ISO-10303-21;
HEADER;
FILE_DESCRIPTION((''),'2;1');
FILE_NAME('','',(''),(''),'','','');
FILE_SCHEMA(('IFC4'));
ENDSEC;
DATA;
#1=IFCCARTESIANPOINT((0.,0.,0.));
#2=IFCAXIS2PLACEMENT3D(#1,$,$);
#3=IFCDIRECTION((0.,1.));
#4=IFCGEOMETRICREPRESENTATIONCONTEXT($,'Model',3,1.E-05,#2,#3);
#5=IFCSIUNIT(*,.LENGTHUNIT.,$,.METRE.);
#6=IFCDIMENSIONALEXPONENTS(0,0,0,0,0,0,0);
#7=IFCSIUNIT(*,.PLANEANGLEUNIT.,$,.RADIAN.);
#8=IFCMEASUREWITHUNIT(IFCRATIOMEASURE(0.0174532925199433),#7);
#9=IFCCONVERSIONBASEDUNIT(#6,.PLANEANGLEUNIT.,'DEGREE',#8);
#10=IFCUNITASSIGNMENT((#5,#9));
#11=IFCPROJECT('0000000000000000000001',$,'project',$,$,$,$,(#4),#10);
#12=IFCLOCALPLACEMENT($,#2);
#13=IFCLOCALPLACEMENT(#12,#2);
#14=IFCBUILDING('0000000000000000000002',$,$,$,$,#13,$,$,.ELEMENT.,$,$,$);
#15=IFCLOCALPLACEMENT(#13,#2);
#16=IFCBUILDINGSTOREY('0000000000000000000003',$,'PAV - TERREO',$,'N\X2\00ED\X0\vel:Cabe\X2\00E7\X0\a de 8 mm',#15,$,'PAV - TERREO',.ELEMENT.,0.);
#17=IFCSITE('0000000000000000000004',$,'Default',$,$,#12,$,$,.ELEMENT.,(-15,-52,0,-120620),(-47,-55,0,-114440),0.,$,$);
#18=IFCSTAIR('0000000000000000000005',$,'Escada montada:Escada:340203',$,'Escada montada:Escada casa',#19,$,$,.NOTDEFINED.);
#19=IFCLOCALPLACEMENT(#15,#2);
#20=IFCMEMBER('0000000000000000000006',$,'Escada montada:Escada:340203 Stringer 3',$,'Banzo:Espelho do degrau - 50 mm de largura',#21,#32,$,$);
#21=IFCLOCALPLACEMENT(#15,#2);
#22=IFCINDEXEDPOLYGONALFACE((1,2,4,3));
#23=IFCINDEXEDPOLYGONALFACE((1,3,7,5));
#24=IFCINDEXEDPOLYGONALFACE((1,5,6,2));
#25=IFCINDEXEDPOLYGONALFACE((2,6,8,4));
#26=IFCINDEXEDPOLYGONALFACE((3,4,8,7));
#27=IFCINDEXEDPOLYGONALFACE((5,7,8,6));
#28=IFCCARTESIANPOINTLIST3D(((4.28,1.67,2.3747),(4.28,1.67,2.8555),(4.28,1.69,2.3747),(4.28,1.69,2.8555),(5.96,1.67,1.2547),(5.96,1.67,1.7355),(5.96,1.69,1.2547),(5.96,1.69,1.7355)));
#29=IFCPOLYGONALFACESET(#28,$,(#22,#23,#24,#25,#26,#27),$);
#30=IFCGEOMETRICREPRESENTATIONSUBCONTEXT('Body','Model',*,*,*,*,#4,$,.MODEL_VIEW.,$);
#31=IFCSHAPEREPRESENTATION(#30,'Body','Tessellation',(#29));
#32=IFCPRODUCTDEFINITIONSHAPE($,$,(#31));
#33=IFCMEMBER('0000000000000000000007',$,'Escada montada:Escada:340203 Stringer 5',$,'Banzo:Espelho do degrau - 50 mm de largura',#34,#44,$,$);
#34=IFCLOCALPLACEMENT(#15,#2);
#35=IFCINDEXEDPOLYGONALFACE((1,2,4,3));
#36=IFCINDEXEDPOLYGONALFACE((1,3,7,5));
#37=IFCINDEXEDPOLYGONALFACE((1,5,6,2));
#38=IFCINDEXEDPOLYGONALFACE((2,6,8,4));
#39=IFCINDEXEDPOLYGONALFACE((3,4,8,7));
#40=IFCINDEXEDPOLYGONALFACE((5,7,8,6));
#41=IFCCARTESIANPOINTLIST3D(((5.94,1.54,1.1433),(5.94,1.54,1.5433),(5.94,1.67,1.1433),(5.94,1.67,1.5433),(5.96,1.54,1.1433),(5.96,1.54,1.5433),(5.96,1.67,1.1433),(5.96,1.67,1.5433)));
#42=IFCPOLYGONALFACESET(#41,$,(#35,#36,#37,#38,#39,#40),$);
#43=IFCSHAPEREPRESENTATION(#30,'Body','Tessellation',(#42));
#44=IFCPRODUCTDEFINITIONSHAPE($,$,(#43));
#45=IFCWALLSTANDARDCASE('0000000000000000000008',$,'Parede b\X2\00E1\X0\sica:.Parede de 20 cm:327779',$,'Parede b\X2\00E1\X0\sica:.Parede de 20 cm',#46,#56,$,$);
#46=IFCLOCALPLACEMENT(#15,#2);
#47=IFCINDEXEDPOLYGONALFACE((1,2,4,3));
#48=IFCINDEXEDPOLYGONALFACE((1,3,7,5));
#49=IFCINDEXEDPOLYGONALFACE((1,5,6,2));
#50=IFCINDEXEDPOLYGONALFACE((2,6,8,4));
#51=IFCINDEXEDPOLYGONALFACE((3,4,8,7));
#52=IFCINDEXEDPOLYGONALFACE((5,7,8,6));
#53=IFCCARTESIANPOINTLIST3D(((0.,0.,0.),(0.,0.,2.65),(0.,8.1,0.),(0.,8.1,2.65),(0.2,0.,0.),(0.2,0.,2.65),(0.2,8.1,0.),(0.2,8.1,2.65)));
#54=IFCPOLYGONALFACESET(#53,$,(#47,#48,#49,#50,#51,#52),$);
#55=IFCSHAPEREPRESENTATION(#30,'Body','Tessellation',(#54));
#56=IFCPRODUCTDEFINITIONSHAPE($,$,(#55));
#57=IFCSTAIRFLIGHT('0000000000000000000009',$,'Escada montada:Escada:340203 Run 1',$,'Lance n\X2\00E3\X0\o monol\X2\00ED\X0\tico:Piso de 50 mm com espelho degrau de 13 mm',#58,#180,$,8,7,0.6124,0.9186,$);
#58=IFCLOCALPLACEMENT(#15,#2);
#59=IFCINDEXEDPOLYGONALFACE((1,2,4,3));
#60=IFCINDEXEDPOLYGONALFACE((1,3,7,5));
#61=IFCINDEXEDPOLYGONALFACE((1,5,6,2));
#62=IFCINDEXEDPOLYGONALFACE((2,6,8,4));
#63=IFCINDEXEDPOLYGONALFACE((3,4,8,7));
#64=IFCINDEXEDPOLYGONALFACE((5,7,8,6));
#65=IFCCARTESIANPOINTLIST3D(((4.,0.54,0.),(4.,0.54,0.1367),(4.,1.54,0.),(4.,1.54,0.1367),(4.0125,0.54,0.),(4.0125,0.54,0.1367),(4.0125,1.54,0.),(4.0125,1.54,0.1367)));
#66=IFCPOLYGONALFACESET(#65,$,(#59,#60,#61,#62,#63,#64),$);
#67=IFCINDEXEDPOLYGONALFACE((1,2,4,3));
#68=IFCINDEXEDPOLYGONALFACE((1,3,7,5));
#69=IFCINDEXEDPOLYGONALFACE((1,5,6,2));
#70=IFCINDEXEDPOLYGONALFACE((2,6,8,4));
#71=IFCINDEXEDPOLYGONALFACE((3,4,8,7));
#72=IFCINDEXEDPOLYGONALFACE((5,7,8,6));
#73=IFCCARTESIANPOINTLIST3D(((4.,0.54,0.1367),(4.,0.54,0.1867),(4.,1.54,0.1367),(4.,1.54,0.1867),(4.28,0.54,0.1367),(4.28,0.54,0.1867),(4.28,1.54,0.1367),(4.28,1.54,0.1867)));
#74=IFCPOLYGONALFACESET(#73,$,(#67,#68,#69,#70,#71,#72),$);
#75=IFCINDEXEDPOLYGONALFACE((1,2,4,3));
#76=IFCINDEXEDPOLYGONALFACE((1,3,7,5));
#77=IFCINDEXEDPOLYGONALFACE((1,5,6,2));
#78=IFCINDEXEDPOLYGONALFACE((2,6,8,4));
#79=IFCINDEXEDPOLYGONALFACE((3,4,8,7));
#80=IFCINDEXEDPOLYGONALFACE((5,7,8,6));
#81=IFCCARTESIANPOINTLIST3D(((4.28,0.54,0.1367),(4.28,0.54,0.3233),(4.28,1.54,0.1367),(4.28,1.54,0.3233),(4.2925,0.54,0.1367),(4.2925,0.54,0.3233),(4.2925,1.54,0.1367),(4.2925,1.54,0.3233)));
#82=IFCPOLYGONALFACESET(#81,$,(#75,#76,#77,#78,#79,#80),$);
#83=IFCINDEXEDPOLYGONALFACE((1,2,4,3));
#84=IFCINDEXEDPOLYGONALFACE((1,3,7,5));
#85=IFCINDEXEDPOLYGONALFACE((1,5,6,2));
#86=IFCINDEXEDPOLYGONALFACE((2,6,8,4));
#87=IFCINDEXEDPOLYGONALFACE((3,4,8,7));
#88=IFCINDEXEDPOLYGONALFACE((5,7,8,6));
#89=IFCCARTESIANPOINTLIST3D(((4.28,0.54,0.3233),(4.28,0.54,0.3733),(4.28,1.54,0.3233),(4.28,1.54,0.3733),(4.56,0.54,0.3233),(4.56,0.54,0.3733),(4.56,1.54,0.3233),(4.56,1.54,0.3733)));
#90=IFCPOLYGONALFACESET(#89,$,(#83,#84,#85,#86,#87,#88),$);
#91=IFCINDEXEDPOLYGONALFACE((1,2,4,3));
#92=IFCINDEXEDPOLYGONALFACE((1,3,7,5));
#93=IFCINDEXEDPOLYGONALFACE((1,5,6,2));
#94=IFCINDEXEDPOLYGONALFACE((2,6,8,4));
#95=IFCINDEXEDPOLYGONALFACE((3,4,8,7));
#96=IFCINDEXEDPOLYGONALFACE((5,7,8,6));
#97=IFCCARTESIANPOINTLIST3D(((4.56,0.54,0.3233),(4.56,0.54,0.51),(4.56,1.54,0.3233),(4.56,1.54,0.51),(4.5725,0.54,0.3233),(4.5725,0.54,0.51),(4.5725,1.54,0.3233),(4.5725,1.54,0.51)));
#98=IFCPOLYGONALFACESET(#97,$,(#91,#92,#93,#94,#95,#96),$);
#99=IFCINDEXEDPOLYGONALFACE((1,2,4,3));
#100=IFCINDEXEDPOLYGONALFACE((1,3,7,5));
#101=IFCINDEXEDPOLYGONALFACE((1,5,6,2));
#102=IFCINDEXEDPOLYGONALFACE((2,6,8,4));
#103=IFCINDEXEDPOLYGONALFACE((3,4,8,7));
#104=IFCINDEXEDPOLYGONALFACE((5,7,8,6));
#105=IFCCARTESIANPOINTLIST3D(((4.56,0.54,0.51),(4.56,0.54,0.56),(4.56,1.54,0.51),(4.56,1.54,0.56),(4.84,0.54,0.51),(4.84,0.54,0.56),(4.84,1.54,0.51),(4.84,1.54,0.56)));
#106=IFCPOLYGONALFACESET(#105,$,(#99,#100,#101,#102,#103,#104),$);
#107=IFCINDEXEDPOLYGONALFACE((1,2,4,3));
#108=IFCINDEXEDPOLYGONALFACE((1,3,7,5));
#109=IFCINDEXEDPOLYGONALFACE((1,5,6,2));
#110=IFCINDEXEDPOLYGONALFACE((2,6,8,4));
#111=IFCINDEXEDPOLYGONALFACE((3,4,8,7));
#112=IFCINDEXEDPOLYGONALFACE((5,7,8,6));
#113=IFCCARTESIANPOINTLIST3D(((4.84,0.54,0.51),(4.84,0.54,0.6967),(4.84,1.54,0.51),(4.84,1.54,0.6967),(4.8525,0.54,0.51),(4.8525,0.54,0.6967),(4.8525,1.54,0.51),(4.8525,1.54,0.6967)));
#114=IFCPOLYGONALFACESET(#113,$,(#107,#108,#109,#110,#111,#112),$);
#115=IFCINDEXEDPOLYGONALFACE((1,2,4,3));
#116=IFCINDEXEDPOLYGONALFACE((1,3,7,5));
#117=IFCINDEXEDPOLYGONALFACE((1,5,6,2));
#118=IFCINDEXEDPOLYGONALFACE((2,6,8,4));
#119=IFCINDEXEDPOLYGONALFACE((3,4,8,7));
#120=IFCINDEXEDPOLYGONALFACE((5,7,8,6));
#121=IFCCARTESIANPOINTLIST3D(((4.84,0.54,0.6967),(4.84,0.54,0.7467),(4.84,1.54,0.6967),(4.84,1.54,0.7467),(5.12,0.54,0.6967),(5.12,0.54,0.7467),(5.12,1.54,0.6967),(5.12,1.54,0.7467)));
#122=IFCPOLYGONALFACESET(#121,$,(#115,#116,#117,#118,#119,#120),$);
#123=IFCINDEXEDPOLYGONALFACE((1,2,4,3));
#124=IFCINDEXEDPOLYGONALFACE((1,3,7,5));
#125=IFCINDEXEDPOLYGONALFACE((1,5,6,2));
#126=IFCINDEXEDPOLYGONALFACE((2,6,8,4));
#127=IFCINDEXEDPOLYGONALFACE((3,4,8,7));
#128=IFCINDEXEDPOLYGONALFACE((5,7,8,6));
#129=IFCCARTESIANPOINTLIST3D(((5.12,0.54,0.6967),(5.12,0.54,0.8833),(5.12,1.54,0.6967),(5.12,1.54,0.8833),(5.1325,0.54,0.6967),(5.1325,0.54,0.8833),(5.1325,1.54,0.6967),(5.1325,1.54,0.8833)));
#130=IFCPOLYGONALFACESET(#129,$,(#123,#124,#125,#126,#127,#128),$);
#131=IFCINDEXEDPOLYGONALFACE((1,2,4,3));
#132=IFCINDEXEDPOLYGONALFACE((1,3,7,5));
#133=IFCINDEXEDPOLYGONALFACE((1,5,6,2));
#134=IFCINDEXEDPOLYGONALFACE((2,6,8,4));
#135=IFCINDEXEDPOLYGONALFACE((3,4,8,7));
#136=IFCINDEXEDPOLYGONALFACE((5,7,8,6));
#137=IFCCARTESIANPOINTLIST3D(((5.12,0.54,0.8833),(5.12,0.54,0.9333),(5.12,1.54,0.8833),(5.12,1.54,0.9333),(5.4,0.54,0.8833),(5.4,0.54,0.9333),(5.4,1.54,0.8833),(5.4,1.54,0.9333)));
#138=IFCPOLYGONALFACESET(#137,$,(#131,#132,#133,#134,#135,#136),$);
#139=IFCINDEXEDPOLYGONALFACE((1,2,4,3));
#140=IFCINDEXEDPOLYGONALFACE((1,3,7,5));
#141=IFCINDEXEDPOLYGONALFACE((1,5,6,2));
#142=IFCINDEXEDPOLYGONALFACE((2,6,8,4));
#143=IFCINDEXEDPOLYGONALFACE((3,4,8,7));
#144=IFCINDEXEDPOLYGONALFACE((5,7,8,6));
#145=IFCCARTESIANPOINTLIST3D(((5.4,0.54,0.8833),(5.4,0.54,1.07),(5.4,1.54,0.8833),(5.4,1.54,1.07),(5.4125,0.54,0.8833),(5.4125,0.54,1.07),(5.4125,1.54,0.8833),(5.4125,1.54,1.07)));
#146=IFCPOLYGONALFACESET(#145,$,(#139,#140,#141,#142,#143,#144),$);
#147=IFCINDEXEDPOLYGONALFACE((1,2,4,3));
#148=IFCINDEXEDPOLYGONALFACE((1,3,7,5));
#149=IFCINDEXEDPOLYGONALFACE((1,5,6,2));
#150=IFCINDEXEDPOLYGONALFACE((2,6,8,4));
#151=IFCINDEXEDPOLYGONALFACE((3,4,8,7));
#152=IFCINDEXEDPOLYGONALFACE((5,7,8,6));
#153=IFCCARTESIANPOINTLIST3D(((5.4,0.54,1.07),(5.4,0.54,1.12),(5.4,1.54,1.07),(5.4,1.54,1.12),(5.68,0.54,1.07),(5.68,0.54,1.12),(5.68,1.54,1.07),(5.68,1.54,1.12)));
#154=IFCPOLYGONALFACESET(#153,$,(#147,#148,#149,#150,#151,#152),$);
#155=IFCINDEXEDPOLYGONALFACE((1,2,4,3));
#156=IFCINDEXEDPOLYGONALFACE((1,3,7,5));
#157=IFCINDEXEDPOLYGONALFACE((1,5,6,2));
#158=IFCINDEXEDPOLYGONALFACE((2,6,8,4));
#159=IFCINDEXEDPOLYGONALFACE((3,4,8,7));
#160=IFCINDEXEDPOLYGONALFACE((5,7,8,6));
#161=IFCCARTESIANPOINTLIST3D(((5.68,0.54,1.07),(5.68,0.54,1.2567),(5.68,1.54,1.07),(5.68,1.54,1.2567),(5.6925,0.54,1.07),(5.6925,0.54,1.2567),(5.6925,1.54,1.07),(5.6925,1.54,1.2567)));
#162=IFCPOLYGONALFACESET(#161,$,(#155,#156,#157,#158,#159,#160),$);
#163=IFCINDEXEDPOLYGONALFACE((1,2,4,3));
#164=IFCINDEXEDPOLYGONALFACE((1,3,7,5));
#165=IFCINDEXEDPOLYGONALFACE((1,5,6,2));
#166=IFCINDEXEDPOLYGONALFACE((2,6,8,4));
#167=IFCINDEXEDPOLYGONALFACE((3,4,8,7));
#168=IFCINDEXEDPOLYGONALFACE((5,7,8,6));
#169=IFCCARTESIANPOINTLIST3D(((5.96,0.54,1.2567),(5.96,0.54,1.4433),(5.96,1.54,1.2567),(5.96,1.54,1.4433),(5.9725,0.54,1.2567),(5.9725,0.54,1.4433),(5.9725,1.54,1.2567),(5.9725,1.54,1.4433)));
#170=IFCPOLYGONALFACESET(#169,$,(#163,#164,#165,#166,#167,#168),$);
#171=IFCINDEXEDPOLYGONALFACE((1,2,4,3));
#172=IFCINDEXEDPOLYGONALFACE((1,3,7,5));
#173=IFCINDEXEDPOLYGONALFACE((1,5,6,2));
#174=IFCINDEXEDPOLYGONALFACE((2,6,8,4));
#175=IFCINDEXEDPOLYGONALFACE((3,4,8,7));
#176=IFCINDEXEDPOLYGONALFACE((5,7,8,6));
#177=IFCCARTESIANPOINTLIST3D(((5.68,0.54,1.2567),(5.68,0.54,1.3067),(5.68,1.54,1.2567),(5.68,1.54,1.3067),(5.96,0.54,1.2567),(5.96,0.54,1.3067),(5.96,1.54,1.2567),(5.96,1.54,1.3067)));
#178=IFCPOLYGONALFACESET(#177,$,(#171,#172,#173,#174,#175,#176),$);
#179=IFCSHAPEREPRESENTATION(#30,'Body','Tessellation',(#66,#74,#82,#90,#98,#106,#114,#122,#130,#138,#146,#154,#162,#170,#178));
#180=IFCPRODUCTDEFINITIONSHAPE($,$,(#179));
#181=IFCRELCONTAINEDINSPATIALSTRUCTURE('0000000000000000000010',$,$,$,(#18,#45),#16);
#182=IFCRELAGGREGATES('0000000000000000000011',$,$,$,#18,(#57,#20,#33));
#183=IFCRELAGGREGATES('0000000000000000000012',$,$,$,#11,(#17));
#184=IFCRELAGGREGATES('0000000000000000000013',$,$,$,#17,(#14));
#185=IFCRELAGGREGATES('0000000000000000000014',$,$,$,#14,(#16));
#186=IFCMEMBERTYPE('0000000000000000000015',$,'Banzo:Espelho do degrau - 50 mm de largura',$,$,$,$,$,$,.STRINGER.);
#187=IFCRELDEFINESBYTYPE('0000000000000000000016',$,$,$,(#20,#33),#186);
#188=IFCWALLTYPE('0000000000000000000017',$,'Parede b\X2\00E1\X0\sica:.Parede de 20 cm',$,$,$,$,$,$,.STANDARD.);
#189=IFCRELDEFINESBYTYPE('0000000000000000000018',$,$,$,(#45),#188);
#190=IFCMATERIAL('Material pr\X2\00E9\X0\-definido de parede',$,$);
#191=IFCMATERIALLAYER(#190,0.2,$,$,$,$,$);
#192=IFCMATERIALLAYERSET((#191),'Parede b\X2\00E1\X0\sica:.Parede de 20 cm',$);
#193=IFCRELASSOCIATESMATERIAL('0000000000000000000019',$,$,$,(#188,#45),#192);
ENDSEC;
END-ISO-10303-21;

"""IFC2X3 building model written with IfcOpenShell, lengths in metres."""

from ifc_helpers import new_model, entity, si_unit, converted_unit, direction, frame, frame_2d, origin, origin_2d_with_axis, place, context, subcontext, project, spatial, polyline, rectangle, outline, extrude, clip, bounded_halfspace, material, layer, layer_set, layer_usage, type_object, element, aggregate, save


model = new_model("IFC2X3")

# Units and contexts
model_context = context("Model", 3, precision=1e-05, world=origin(), true_north=direction((0.0, 1.0)))
body_context = subcontext(model_context, "Body", "Model", "MODEL_VIEW")
ifc_project = project(units=[si_unit("LENGTHUNIT", "METRE"), converted_unit("PLANEANGLEUNIT", "DEGREE", entity("IfcRatioMeasure", 0.0174532925199433), si_unit("PLANEANGLEUNIT", "RADIAN"), dimensions=[0, 0, 0, 0, 0, 0, 0])], contexts=[model_context])

# Site, building, storey
site_placement = place(None, origin())
site = spatial("IfcSite", under=ifc_project, at=site_placement, Name="Default", CompositionType="ELEMENT", RefLatitude=(-15, -52, 0, -120620), RefLongitude=(-47, -55, 0, -114440), RefElevation=0.0)
building_placement = place(site_placement, origin())
building = spatial("IfcBuilding", under=site, at=building_placement, CompositionType="ELEMENT")
storey_placement = place(building_placement, origin())
storey = spatial("IfcBuildingStorey", under=building, at=storey_placement, Name="PAV - TERREO", ObjectType="Nível:Cabeça de 8 mm", LongName="PAV - TERREO", CompositionType="ELEMENT", Elevation=0.0)

# Stair, members
stair_placement = place(storey_placement, origin())
stair = element("IfcStair", 1, at=stair_placement, inside=storey, Name="Escada montada:Escada:340203", ObjectType="Escada montada:Escada casa", ShapeType="NOTDEFINED")
member_type = type_object("IfcMemberType", Name="Banzo:Espelho do degrau - 50 mm de largura", PredefinedType="STRINGER")
member_1_placement = place(stair_placement, origin())
member_1 = element("IfcMember", 2, at=member_1_placement, type_object=member_type, Name="Escada montada:Escada:340203 Stringer 3", ObjectType="Banzo:Espelho do degrau - 50 mm de largura", context=body_context, shape_type="SweptSolid", body=[
    extrude(outline(polyline([(-1.1429, -0.2), (0.8762, -0.2), (1.1429, 0.2), (-0.8762, 0.2), (-1.1429, -0.2)])), frame((5.12, 1.67, 2.0551), z_axis=(0.0, 1.0, 0.0), x_axis=(-0.83205, 0.0, 0.5547)), (0.0, 0.0, 1.0), 0.02),
])
member_2_placement = place(stair_placement, origin())
member_2 = element("IfcMember", 3, at=member_2_placement, type_object=member_type, Name="Escada montada:Escada:340203 Stringer 5", ObjectType="Banzo:Espelho do degrau - 50 mm de largura", context=body_context, shape_type="SweptSolid", body=[
    extrude(rectangle(XDim=0.13, YDim=0.02, at=frame_2d((0.0, 0.0), x_axis=(1.0, 0.0))), frame((5.95, 1.605, 1.1433), z_axis=(0.0, 0.0, 1.0), x_axis=(0.0, -1.0, 0.0)), (0.0, 0.0, 1.0), 0.4),
])

# Wall
ifc_material_1 = material(Name="Material pré-definido de parede")
ifc_layer_1 = layer(ifc_material_1, 0.2)
ifc_layer_set_1 = layer_set([ifc_layer_1], Name="Parede básica:.Parede de 20 cm")
ifc_layer_usage_1 = layer_usage(ifc_layer_set_1, "AXIS2", "NEGATIVE", 0.1)
wall_type = type_object("IfcWallType", Name="Parede básica:.Parede de 20 cm", PredefinedType="STANDARD", material=ifc_layer_set_1)
wall_placement = place(storey_placement, frame((0.1, 0.0, 0.0), z_axis=(0.0, 0.0, 1.0), x_axis=(0.0, 1.0, 0.0)))
element("IfcWallStandardCase", 4, at=wall_placement, inside=storey, type_object=wall_type, material=ifc_layer_usage_1, Name="Parede básica:.Parede de 20 cm:327779", ObjectType="Parede básica:.Parede de 20 cm", context=body_context, shape_type="Clipping", body=[
    clip(extrude(rectangle(XDim=8.1, YDim=0.2, at=frame_2d((4.05, 0.0), x_axis=(-1.0, 0.0))), origin(), (0.0, 0.0, 1.0), 2.65), bounded_halfspace(frame((0.0, -0.1, 2.65), z_axis=(0.0, 0.0, -1.0), x_axis=(-1.0, 0.0, 0.0)), True, frame((0.0, -0.1, 2.65)), polyline([(0.0, 0.0), (0.3, 0.0), (0.5, 0.0), (7.9, 0.0), (8.1, 0.0), (8.1, 0.2), (0.0, 0.2), (0.0, 0.0)]))),
])

# Stair flight
stair_flight_1_placement = place(stair_placement, origin())
stair_flight_1 = element("IfcStairFlight", 5, at=stair_flight_1_placement, Name="Escada montada:Escada:340203 Run 1", ObjectType="Lance não monolítico:Piso de 50 mm com espelho degrau de 13 mm", NumberOfRiser=8, NumberOfTreads=7, RiserHeight=0.6124, TreadLength=0.9186, context=body_context, shape_type="SweptSolid", body=[
    extrude(rectangle(XDim=1.0, YDim=0.0125, at=frame_2d((0.0, 0.0), x_axis=(1.0, 0.0))), frame((4.0063, 1.04, 0.0), z_axis=(0.0, 0.0, 1.0), x_axis=(0.0, 1.0, 0.0)), (0.0, 0.0, 1.0), 0.1367),
    extrude(rectangle(XDim=0.28, YDim=1.0, at=origin_2d_with_axis()), frame((4.14, 1.04, 0.1367), z_axis=(0.0, 0.0, 1.0), x_axis=(-1.0, 0.0, 0.0)), (0.0, 0.0, 1.0), 0.05),
    extrude(rectangle(XDim=1.0, YDim=0.0125, at=frame_2d((0.0, 0.0), x_axis=(1.0, 0.0))), frame((4.2863, 1.04, 0.1367), z_axis=(0.0, 0.0, 1.0), x_axis=(0.0, 1.0, 0.0)), (0.0, 0.0, 1.0), 0.1867),
    extrude(rectangle(XDim=0.28, YDim=1.0, at=frame_2d((0.0, 0.0), x_axis=(1.0, 0.0))), frame((4.42, 1.04, 0.3233), z_axis=(0.0, 0.0, 1.0), x_axis=(-1.0, 0.0, 0.0)), (0.0, 0.0, 1.0), 0.05),
    extrude(rectangle(XDim=1.0, YDim=0.0125, at=frame_2d((0.0, 0.0), x_axis=(1.0, 0.0))), frame((4.5663, 1.04, 0.3233), z_axis=(0.0, 0.0, 1.0), x_axis=(0.0, 1.0, 0.0)), (0.0, 0.0, 1.0), 0.1867),
    extrude(rectangle(XDim=0.28, YDim=1.0, at=frame_2d((0.0, 0.0), x_axis=(1.0, 0.0))), frame((4.7, 1.04, 0.51), z_axis=(0.0, 0.0, 1.0), x_axis=(-1.0, 0.0, 0.0)), (0.0, 0.0, 1.0), 0.05),
    extrude(rectangle(XDim=1.0, YDim=0.0125, at=frame_2d((0.0, 0.0), x_axis=(1.0, 0.0))), frame((4.8463, 1.04, 0.51), z_axis=(0.0, 0.0, 1.0), x_axis=(0.0, 1.0, 0.0)), (0.0, 0.0, 1.0), 0.1867),
    extrude(rectangle(XDim=0.28, YDim=1.0, at=frame_2d((0.0, 0.0), x_axis=(1.0, 0.0))), frame((4.98, 1.04, 0.6967), z_axis=(0.0, 0.0, 1.0), x_axis=(-1.0, 0.0, 0.0)), (0.0, 0.0, 1.0), 0.05),
    extrude(rectangle(XDim=1.0, YDim=0.0125, at=frame_2d((0.0, 0.0), x_axis=(1.0, 0.0))), frame((5.1263, 1.04, 0.6967), z_axis=(0.0, 0.0, 1.0), x_axis=(0.0, 1.0, 0.0)), (0.0, 0.0, 1.0), 0.1867),
    extrude(rectangle(XDim=0.28, YDim=1.0, at=frame_2d((0.0, 0.0), x_axis=(1.0, 0.0))), frame((5.26, 1.04, 0.8833), z_axis=(0.0, 0.0, 1.0), x_axis=(-1.0, 0.0, 0.0)), (0.0, 0.0, 1.0), 0.05),
    extrude(rectangle(XDim=1.0, YDim=0.0125, at=origin_2d_with_axis()), frame((5.4063, 1.04, 0.8833), z_axis=(0.0, 0.0, 1.0), x_axis=(0.0, 1.0, 0.0)), (0.0, 0.0, 1.0), 0.1867),
    extrude(rectangle(XDim=0.28, YDim=1.0, at=frame_2d((0.0, 0.0), x_axis=(1.0, 0.0))), frame((5.54, 1.04, 1.07), z_axis=(0.0, 0.0, 1.0), x_axis=(-1.0, 0.0, 0.0)), (0.0, 0.0, 1.0), 0.05),
    extrude(rectangle(XDim=1.0, YDim=0.0125, at=origin_2d_with_axis()), frame((5.6863, 1.04, 1.07), z_axis=(0.0, 0.0, 1.0), x_axis=(0.0, 1.0, 0.0)), (0.0, 0.0, 1.0), 0.1867),
    extrude(rectangle(XDim=1.0, YDim=0.0125, at=origin_2d_with_axis()), frame((5.9663, 1.04, 1.2567), z_axis=(0.0, 0.0, 1.0), x_axis=(0.0, 1.0, 0.0)), (0.0, 0.0, 1.0), 0.1867),
    extrude(rectangle(XDim=0.28, YDim=1.0, at=frame_2d((0.0, 0.0), x_axis=(1.0, 0.0))), frame((5.82, 1.04, 1.2567), z_axis=(0.0, 0.0, 1.0), x_axis=(-1.0, 0.0, 0.0)), (0.0, 0.0, 1.0), 0.05),
])
aggregate(stair, [stair_flight_1, member_1, member_2])

save(model, "model.ifc")
